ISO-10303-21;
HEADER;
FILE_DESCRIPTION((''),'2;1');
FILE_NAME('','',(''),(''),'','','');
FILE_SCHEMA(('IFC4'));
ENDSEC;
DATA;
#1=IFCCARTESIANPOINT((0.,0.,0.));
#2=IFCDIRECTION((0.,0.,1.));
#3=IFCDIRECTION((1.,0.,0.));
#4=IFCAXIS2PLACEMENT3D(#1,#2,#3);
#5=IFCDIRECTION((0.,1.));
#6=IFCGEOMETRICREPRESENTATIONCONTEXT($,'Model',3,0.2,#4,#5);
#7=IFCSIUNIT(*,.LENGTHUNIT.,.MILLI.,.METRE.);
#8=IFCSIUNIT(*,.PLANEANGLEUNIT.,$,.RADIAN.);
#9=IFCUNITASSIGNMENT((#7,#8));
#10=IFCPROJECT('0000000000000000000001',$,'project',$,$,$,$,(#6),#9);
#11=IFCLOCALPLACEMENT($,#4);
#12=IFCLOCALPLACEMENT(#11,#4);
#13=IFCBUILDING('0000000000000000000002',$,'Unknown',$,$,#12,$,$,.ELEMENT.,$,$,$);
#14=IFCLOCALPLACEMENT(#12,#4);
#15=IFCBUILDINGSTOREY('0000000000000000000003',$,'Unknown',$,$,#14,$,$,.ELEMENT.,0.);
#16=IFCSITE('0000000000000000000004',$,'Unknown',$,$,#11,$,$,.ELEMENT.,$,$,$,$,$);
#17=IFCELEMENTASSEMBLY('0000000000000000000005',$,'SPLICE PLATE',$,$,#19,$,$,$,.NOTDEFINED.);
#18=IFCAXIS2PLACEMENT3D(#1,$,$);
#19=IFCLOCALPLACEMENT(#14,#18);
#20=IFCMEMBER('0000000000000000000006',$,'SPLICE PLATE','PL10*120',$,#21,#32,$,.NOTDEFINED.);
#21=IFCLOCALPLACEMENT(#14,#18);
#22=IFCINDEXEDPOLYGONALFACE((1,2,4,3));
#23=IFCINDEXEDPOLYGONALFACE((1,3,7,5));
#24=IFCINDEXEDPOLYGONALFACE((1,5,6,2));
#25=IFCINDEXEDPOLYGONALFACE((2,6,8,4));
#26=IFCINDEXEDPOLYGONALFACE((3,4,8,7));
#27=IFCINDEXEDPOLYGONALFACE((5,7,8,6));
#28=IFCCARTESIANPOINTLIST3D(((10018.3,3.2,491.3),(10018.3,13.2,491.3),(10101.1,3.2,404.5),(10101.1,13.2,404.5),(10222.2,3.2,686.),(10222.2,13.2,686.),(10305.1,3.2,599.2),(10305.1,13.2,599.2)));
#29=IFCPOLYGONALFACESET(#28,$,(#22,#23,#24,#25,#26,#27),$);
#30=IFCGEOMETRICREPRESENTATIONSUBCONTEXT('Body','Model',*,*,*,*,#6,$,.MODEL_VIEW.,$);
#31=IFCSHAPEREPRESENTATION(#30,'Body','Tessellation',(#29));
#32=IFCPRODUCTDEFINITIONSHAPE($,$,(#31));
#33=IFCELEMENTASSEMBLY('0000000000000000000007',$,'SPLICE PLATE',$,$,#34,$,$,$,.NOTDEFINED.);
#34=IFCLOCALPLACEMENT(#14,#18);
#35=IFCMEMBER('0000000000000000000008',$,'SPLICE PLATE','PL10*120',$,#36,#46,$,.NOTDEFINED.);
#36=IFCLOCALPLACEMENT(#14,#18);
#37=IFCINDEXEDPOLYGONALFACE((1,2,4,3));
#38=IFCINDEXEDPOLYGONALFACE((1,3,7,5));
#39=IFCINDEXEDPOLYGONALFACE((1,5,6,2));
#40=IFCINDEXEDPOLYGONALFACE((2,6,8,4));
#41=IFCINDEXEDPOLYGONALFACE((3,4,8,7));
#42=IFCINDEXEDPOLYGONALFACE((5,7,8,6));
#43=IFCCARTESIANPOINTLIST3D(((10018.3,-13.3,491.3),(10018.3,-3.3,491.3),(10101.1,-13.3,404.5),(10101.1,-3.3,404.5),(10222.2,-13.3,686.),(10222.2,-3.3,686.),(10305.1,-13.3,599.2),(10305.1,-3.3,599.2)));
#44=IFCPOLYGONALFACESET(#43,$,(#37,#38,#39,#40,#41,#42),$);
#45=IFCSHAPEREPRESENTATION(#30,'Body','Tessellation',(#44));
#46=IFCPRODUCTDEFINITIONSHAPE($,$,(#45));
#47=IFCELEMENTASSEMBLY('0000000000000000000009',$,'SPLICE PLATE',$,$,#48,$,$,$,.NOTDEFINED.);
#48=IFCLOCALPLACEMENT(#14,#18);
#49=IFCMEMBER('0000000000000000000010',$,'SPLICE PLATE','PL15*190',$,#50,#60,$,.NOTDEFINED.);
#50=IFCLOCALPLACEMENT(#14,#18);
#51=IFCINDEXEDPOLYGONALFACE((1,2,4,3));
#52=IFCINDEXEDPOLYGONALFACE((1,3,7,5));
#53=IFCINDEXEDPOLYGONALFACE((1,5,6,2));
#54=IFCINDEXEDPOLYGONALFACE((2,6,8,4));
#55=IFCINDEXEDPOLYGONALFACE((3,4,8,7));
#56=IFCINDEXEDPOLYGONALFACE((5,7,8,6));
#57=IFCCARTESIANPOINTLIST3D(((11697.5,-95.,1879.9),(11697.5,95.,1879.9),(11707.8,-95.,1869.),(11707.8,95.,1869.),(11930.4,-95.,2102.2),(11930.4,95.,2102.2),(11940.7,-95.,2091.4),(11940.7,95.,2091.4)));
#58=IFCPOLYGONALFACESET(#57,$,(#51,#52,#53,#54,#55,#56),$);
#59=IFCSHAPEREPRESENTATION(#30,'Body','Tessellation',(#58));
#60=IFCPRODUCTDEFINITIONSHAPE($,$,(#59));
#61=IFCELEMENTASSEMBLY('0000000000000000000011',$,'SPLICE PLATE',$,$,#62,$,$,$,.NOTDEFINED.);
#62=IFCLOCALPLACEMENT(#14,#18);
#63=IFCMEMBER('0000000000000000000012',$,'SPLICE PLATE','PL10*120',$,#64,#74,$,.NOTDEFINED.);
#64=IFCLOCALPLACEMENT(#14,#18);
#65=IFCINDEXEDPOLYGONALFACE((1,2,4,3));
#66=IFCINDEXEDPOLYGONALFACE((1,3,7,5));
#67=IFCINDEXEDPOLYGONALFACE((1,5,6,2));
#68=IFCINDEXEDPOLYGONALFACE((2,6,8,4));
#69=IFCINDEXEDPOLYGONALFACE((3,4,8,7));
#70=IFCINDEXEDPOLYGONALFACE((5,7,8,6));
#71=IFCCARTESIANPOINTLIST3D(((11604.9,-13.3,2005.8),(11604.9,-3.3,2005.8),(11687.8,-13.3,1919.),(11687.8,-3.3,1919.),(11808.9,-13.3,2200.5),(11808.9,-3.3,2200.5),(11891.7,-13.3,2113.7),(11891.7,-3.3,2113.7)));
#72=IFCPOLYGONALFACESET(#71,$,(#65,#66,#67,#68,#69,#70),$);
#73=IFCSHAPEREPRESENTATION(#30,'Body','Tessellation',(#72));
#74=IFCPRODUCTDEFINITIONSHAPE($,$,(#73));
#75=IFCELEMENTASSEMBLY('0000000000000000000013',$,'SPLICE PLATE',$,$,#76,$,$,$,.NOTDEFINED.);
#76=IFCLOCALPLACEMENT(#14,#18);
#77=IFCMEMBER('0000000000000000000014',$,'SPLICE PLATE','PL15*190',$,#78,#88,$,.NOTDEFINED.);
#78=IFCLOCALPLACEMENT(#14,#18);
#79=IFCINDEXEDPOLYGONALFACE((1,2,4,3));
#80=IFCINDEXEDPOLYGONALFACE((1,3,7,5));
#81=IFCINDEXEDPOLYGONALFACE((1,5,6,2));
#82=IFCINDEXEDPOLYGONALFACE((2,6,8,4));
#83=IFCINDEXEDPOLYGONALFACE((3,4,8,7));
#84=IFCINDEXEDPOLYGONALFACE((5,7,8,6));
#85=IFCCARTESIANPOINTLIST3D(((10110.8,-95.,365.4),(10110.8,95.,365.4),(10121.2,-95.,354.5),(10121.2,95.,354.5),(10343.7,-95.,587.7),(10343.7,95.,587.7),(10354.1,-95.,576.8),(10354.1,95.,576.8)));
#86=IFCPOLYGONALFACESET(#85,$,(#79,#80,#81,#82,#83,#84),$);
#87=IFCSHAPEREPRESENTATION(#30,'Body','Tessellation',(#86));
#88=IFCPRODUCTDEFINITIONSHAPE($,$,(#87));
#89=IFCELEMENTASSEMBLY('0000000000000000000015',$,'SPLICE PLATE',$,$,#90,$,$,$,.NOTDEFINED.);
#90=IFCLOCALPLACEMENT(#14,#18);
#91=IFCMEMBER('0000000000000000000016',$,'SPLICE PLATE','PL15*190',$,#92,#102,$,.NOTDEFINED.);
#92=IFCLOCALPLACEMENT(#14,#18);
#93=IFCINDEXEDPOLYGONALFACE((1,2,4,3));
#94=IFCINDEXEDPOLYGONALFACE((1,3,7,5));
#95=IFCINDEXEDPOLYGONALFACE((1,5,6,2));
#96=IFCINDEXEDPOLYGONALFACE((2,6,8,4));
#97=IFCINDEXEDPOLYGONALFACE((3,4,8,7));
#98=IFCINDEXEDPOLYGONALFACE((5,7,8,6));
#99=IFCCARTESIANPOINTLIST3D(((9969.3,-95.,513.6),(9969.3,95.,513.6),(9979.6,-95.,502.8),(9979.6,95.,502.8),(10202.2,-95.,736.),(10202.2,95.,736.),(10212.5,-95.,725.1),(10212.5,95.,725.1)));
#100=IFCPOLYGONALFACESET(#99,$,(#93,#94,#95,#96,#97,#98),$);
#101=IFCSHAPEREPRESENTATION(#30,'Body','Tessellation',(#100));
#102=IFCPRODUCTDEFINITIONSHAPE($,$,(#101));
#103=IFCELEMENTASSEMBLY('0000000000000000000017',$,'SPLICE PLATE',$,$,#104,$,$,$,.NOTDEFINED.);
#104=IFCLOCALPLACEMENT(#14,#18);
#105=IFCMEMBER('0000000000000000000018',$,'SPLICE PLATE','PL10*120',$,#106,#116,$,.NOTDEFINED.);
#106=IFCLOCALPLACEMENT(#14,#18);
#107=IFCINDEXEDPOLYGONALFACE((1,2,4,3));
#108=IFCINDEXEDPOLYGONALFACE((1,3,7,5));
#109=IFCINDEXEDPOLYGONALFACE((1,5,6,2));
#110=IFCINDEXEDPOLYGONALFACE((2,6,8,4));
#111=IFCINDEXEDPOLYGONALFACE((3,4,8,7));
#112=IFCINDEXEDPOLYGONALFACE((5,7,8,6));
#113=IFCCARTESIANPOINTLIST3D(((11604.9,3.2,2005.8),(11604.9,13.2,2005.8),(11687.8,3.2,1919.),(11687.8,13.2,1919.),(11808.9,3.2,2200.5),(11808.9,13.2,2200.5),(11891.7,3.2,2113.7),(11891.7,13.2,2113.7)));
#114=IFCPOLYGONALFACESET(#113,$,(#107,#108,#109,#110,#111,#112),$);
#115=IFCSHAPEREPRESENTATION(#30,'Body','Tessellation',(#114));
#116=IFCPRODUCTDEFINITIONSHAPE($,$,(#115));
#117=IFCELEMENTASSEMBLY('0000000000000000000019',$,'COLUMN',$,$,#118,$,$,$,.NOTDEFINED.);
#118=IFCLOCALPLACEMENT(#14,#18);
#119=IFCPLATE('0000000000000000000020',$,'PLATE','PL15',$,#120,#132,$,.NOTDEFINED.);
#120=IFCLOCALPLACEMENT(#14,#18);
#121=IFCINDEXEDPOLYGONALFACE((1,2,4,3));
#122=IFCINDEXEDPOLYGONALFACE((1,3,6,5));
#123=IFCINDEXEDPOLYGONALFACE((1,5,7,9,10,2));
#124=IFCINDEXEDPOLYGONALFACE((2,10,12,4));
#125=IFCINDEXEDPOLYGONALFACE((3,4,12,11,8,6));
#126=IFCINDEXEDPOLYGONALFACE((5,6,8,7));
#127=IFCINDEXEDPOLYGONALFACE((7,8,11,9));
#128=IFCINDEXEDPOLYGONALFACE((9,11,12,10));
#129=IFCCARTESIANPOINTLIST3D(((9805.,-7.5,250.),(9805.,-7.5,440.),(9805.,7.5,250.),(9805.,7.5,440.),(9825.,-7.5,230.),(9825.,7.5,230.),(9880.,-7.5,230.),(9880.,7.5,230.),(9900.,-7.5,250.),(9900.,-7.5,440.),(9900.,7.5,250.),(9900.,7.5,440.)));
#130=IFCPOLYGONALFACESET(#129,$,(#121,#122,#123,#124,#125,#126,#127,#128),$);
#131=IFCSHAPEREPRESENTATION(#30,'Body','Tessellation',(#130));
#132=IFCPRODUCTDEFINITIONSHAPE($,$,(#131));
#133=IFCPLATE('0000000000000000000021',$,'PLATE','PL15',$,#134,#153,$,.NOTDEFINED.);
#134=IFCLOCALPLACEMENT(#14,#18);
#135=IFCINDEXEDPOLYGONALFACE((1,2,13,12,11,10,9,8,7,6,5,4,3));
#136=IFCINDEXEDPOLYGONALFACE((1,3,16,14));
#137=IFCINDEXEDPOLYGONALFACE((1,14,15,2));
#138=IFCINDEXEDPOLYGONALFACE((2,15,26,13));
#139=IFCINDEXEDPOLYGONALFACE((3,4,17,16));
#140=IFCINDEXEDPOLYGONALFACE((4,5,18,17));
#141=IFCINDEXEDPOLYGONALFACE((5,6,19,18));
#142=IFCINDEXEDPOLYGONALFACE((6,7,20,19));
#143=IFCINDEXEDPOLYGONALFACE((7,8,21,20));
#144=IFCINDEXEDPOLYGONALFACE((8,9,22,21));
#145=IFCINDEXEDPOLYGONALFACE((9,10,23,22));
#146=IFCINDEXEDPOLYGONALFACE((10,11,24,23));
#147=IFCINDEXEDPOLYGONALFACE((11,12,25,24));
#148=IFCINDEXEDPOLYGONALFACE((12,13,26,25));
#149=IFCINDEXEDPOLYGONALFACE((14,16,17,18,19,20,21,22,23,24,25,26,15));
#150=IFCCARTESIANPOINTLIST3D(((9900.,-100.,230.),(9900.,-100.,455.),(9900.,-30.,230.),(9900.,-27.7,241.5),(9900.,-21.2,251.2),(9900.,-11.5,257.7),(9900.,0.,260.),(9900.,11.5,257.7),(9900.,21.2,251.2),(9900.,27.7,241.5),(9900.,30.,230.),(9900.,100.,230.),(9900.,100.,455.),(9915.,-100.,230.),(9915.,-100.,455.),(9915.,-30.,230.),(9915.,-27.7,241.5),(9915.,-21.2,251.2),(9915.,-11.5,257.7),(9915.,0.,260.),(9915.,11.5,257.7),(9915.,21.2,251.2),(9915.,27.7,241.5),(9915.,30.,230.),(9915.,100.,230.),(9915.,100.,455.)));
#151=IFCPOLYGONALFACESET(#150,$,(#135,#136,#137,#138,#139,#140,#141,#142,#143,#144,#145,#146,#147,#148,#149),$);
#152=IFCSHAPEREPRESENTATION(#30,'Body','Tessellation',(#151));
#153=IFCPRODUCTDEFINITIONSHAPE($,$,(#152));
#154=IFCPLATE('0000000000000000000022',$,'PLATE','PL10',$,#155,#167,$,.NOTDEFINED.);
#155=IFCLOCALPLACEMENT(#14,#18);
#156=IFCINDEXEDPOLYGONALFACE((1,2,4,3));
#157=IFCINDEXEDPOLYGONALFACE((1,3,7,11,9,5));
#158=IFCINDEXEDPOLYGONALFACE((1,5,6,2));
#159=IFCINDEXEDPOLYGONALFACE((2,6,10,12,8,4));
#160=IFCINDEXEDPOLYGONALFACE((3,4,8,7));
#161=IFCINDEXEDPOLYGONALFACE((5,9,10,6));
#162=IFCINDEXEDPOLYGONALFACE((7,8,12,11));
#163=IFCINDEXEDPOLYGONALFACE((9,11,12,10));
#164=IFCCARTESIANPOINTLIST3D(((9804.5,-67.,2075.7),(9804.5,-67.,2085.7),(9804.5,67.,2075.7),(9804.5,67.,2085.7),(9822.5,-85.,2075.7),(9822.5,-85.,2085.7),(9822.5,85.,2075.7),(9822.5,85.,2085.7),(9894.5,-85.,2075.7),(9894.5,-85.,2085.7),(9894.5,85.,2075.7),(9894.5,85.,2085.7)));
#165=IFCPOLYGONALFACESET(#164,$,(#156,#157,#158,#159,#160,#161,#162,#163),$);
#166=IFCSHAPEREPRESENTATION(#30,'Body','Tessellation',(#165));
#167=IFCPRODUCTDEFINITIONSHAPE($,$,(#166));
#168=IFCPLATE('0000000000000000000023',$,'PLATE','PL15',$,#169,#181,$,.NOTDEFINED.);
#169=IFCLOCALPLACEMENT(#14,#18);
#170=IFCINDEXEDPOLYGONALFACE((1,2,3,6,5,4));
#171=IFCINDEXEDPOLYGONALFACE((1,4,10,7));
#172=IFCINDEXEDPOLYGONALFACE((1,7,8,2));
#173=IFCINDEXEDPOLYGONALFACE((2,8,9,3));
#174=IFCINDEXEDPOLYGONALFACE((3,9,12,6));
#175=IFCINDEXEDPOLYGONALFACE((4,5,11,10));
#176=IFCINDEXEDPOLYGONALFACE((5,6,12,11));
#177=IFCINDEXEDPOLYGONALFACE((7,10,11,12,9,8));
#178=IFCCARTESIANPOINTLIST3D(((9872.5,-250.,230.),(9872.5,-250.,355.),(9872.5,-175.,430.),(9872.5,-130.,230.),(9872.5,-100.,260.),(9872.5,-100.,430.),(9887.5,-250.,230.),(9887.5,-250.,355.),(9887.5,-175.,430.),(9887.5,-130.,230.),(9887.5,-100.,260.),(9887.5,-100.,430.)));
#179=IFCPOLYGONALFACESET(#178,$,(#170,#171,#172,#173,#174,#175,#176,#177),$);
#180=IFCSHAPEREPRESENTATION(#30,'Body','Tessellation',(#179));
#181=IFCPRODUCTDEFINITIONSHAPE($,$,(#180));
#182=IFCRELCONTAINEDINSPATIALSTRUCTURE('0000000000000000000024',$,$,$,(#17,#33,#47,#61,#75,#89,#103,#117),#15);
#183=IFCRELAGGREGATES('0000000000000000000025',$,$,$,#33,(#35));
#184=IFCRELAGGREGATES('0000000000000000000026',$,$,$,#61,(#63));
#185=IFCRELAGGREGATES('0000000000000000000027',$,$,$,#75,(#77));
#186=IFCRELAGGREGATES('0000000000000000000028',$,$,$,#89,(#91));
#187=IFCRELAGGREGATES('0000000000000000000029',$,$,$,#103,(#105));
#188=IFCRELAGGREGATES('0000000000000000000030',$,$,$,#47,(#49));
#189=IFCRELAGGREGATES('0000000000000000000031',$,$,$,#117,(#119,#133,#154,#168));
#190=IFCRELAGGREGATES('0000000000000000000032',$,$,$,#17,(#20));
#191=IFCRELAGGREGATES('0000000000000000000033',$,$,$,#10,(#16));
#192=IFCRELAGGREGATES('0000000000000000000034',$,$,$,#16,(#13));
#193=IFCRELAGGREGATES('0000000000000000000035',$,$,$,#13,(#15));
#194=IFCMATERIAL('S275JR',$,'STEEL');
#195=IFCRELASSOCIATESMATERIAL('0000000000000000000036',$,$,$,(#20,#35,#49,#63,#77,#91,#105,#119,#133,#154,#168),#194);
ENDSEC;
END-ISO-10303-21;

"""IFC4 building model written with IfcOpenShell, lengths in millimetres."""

from ifc_helpers import new_model, si_unit, direction, frame, origin_with_axes, place, context, subcontext, project, spatial, line, indexed_curve, outline, extrude, material, element, aggregate, save


model = new_model("IFC4")

# Units and contexts
model_context = context("Model", 3, precision=0.2, world=origin_with_axes(), true_north=direction((0.0, 1.0)))
body_context = subcontext(model_context, "Body", "Model", "MODEL_VIEW")
ifc_project = project(units=[si_unit("LENGTHUNIT", "METRE", prefix="MILLI"), si_unit("PLANEANGLEUNIT", "RADIAN")], contexts=[model_context])

# Site, building, storey
site_placement = place(None, origin_with_axes())
site = spatial("IfcSite", under=ifc_project, at=site_placement, Name="Unknown", CompositionType="ELEMENT")
building_placement = place(site_placement, origin_with_axes())
building = spatial("IfcBuilding", under=site, at=building_placement, Name="Unknown", CompositionType="ELEMENT")
storey_placement = place(building_placement, origin_with_axes())
storey = spatial("IfcBuildingStorey", under=building, at=storey_placement, Name="Unknown", CompositionType="ELEMENT", Elevation=0.0)

# Element assemblies, members
assembly_1_placement = place(storey_placement, frame((10059.7, 8.2, 447.9), z_axis=(-0.000002, -1.0, 0.0), x_axis=(0.723355, 0.0, 0.690476)))
assembly_1 = element("IfcElementAssembly", 1, at=assembly_1_placement, inside=storey, Name="SPLICE PLATE", PredefinedType="NOTDEFINED")
ifc_material_1 = material(Name="S275JR", Category="STEEL")
member_1_placement = place(assembly_1_placement, origin_with_axes())
member_1 = element("IfcMember", 2, at=member_1_placement, material=ifc_material_1, Name="SPLICE PLATE", Description="PL10*120", PredefinedType="NOTDEFINED", context=body_context, shape_type="SolidModel", body=[
    extrude(outline(indexed_curve([(-5.0, -60.0), (5.0, -60.0), (5.0, 60.0), (-5.0, 60.0)], segments=[line(1, 2, 3, 4, 1)])), frame((0.0, 0.0, 0.0), z_axis=(-1.0, 0.0, 0.0), x_axis=(0.0, 0.0, 1.0)), (0.0, -0.000002, -1.0), 282.0),
])
assembly_2_placement = place(storey_placement, frame((10059.7, -8.3, 447.9), z_axis=(-0.000002, -1.0, 0.0), x_axis=(0.723355, 0.0, 0.690476)))
assembly_2 = element("IfcElementAssembly", 3, at=assembly_2_placement, inside=storey, Name="SPLICE PLATE", PredefinedType="NOTDEFINED")
member_2_placement = place(assembly_2_placement, origin_with_axes())
member_2 = element("IfcMember", 4, at=member_2_placement, material=ifc_material_1, Name="SPLICE PLATE", Description="PL10*120", PredefinedType="NOTDEFINED", context=body_context, shape_type="SolidModel", body=[
    extrude(outline(indexed_curve([(-5.0, -60.0), (5.0, -60.0), (5.0, 60.0), (-5.0, 60.0)], segments=[line(1, 2, 3, 4, 1)])), frame((0.0, 0.0, 0.0), z_axis=(-1.0, 0.0, 0.0), x_axis=(0.0, 0.0, 1.0)), (0.0, -0.000002, -1.0), 282.0),
])
aggregate(assembly_2, [member_2])
assembly_3_placement = place(storey_placement, frame((11935.6, 0.0, 2096.8), z_axis=(0.690476, 0.0, -0.723355), x_axis=(-0.723355, 0.0, -0.690476)))
assembly_3 = element("IfcElementAssembly", 5, at=assembly_3_placement, inside=storey, Name="SPLICE PLATE", PredefinedType="NOTDEFINED")
member_3_placement = place(assembly_3_placement, origin_with_axes())
member_3 = element("IfcMember", 6, at=member_3_placement, material=ifc_material_1, Name="SPLICE PLATE", Description="PL15*190", PredefinedType="NOTDEFINED", context=body_context, shape_type="SolidModel", body=[
    extrude(outline(indexed_curve([(-7.5, -95.0), (7.5, -95.0), (7.5, 95.0), (-7.5, 95.0)], segments=[line(1, 2, 3, 4, 1)])), frame((0.0, 0.0, 0.0), z_axis=(-1.0, 0.0, 0.0), x_axis=(0.0, 0.0, 1.0)), (0.0, -0.000002, -1.0), 322.0),
])
assembly_4_placement = place(storey_placement, frame((11850.3, -8.3, 2157.1), z_axis=(0.0, 1.0, 0.0), x_axis=(-0.723355, 0.0, -0.690476)))
assembly_4 = element("IfcElementAssembly", 7, at=assembly_4_placement, inside=storey, Name="SPLICE PLATE", PredefinedType="NOTDEFINED")
member_4_placement = place(assembly_4_placement, origin_with_axes())
member_4 = element("IfcMember", 8, at=member_4_placement, material=ifc_material_1, Name="SPLICE PLATE", Description="PL10*120", PredefinedType="NOTDEFINED", context=body_context, shape_type="SolidModel", body=[
    extrude(outline(indexed_curve([(-5.0, -60.0), (5.0, -60.0), (5.0, 60.0), (-5.0, 60.0)], segments=[line(1, 2, 3, 4, 1)])), frame((0.0, 0.0, 0.0), z_axis=(-1.0, 0.0, 0.0), x_axis=(0.0, 0.0, 1.0)), (0.0, -0.000002, -1.0), 282.0),
])
aggregate(assembly_4, [member_4])
assembly_5_placement = place(storey_placement, frame((10116.0, 0.0, 359.9), z_axis=(0.690476, 0.0, -0.723355), x_axis=(0.723355, 0.0, 0.690476)))
assembly_5 = element("IfcElementAssembly", 9, at=assembly_5_placement, inside=storey, Name="SPLICE PLATE", PredefinedType="NOTDEFINED")
member_5_placement = place(assembly_5_placement, origin_with_axes())
member_5 = element("IfcMember", 10, at=member_5_placement, material=ifc_material_1, Name="SPLICE PLATE", Description="PL15*190", PredefinedType="NOTDEFINED", context=body_context, shape_type="SolidModel", body=[
    extrude(outline(indexed_curve([(-7.5, -95.0), (7.5, -95.0), (7.5, 95.0), (-7.5, 95.0)], segments=[line(1, 2, 3, 4, 1)])), frame((0.0, 0.0, 0.0), z_axis=(-1.0, 0.0, 0.0), x_axis=(0.0, 0.0, 1.0)), (0.0, -0.000002, -1.0), 322.0),
])
aggregate(assembly_5, [member_5])
assembly_6_placement = place(storey_placement, frame((9974.4, 0.0, 508.2), z_axis=(0.690476, 0.0, -0.723355), x_axis=(0.723355, 0.0, 0.690476)))
assembly_6 = element("IfcElementAssembly", 11, at=assembly_6_placement, inside=storey, Name="SPLICE PLATE", PredefinedType="NOTDEFINED")
member_6_placement = place(assembly_6_placement, origin_with_axes())
member_6 = element("IfcMember", 12, at=member_6_placement, material=ifc_material_1, Name="SPLICE PLATE", Description="PL15*190", PredefinedType="NOTDEFINED", context=body_context, shape_type="SolidModel", body=[
    extrude(outline(indexed_curve([(-7.5, -95.0), (7.5, -95.0), (7.5, 95.0), (-7.5, 95.0)], segments=[line(1, 2, 3, 4, 1)])), frame((0.0, 0.0, 0.0), z_axis=(-1.0, 0.0, 0.0), x_axis=(0.0, 0.0, 1.0)), (0.0, -0.000002, -1.0), 322.0),
])
aggregate(assembly_6, [member_6])
assembly_7_placement = place(storey_placement, frame((11850.3, 8.2, 2157.1), z_axis=(0.0, 1.0, 0.0), x_axis=(-0.723355, 0.0, -0.690476)))
assembly_7 = element("IfcElementAssembly", 13, at=assembly_7_placement, inside=storey, Name="SPLICE PLATE", PredefinedType="NOTDEFINED")
member_7_placement = place(assembly_7_placement, origin_with_axes())
member_7 = element("IfcMember", 14, at=member_7_placement, material=ifc_material_1, Name="SPLICE PLATE", Description="PL10*120", PredefinedType="NOTDEFINED", context=body_context, shape_type="SolidModel", body=[
    extrude(outline(indexed_curve([(-5.0, -60.0), (5.0, -60.0), (5.0, 60.0), (-5.0, 60.0)], segments=[line(1, 2, 3, 4, 1)])), frame((0.0, 0.0, 0.0), z_axis=(-1.0, 0.0, 0.0), x_axis=(0.0, 0.0, 1.0)), (0.0, -0.000002, -1.0), 282.0),
])
aggregate(assembly_7, [member_7])

# Element assembly, plates, voiding feature
assembly_8_placement = place(storey_placement, frame((9800.0, 0.0, 200.0), z_axis=(-1.0, 0.0, 0.0), x_axis=(0.0, 0.0, 1.0)))
assembly_8 = element("IfcElementAssembly", 15, at=assembly_8_placement, inside=storey, Name="COLUMN", PredefinedType="NOTDEFINED")
plate_1_placement = place(assembly_8_placement, frame((240.0, 0.0, -100.0), z_axis=(-0.000002, -1.0, 0.0), x_axis=(0.0, 0.0, 1.0)))
plate_1 = element("IfcPlate", 16, at=plate_1_placement, material=ifc_material_1, Name="PLATE", Description="PL15", PredefinedType="NOTDEFINED", context=body_context, shape_type="SolidModel", body=[
    extrude(outline(indexed_curve([(0.0, 0.0), (95.0, 0.0), (95.0, 190.0), (75.0, 210.0), (20.0, 210.0), (0.0, 190.0)], segments=[line(1, 2, 3, 4, 5, 6, 1)])), frame((0.0, 0.0, 7.5), z_axis=(0.0, 0.0, 1.0), x_axis=(1.0, 0.0, 0.0)), (0.0, -0.000002, -1.0), 15.0),
])
plate_2_placement = place(assembly_8_placement, frame((30.0, -100.0, -107.5), z_axis=(0.0, 0.0, 1.0), x_axis=(1.0, 0.0, 0.0)))
plate_2 = element("IfcPlate", 17, at=plate_2_placement, material=ifc_material_1, Name="PLATE", Description="PL15", PredefinedType="NOTDEFINED", context=body_context, shape_type="SolidModel", body=[
    extrude(outline(indexed_curve([(0.0, 0.0), (225.0, 0.0), (225.0, 200.0), (0.0, 200.0)], segments=[line(1, 2, 3, 4, 1)])), frame((0.0, 0.0, 7.5), z_axis=(0.0, 0.0, 1.0), x_axis=(1.0, 0.0, 0.0)), (0.0, -0.000002, -1.0), 15.0),
])
voiding_feature_placement = place(plate_2_placement, frame((0.0, 100.0, 27.5), z_axis=(-0.000002, -1.0, 0.0), x_axis=(0.0, -0.000002, -1.0)))
element("IfcVoidingFeature", 18, at=voiding_feature_placement, cuts=plate_2, Name="BEAM", PredefinedType="HOLE", context=body_context, shape_type="SolidModel", body=[
    extrude(outline(indexed_curve([(30.0, 0.0), (27.7, 11.5), (21.2, 21.2), (11.5, 27.7), (0.0, 30.0), (-11.5, 27.7), (-21.2, 21.2), (-27.7, 11.5), (-30.0, 0.0), (-27.7, -11.5), (-21.2, -21.2), (-11.5, -27.7), (0.0, -30.0), (11.5, -27.7), (21.2, -21.2), (27.7, -11.5)], segments=[line(1, 2, 3, 4, 5, 6, 7, 8, 9, 10, 11, 12, 13, 14, 15, 16, 1)])), frame((0.0, 0.0, 0.0), z_axis=(-1.0, 0.0, 0.0), x_axis=(0.0, 0.0, 1.0)), (0.0, -0.000002, -1.0), 120.0),
])
plate_3_placement = place(assembly_8_placement, frame((1880.7, 85.0, -94.5), z_axis=(1.0, 0.0, 0.0), x_axis=(0.0, 0.0, 1.0)))
plate_3 = element("IfcPlate", 19, at=plate_3_placement, material=ifc_material_1, Name="PLATE", Description="PL10", PredefinedType="NOTDEFINED", context=body_context, shape_type="SolidModel", body=[
    extrude(outline(indexed_curve([(0.0, 0.0), (72.0, 0.0), (90.0, 18.0), (90.0, 152.0), (72.0, 170.0), (0.0, 170.0)], segments=[line(1, 2, 3, 4, 5, 6, 1)])), frame((0.0, 0.0, 5.0), z_axis=(0.0, 0.0, 1.0), x_axis=(1.0, 0.0, 0.0)), (0.0, -0.000002, -1.0), 10.0),
])
plate_4_placement = place(assembly_8_placement, frame((60.0, -100.0, -80.0), z_axis=(0.0, 0.0, 1.0), x_axis=(-0.707116, -0.707097, 0.0)))
plate_4 = element("IfcPlate", 20, at=plate_4_placement, material=ifc_material_1, Name="PLATE", Description="PL15", PredefinedType="NOTDEFINED", context=body_context, shape_type="SolidModel", body=[
    extrude(outline(indexed_curve([(0.0, 0.0), (42.4, 0.0), (127.3, 84.9), (38.9, 173.2), (-67.2, 173.2), (-120.2, 120.2)], segments=[line(1, 2, 3, 4, 5, 6, 1)])), frame((0.0, 0.0, 7.5), z_axis=(0.0, 0.0, 1.0), x_axis=(1.0, 0.0, 0.0)), (0.0, -0.000002, -1.0), 15.0),
])

aggregate(assembly_3, [member_3])

aggregate(assembly_8, [plate_1, plate_2, plate_3, plate_4])
aggregate(assembly_1, [member_1])

save(model, "model.ifc")
